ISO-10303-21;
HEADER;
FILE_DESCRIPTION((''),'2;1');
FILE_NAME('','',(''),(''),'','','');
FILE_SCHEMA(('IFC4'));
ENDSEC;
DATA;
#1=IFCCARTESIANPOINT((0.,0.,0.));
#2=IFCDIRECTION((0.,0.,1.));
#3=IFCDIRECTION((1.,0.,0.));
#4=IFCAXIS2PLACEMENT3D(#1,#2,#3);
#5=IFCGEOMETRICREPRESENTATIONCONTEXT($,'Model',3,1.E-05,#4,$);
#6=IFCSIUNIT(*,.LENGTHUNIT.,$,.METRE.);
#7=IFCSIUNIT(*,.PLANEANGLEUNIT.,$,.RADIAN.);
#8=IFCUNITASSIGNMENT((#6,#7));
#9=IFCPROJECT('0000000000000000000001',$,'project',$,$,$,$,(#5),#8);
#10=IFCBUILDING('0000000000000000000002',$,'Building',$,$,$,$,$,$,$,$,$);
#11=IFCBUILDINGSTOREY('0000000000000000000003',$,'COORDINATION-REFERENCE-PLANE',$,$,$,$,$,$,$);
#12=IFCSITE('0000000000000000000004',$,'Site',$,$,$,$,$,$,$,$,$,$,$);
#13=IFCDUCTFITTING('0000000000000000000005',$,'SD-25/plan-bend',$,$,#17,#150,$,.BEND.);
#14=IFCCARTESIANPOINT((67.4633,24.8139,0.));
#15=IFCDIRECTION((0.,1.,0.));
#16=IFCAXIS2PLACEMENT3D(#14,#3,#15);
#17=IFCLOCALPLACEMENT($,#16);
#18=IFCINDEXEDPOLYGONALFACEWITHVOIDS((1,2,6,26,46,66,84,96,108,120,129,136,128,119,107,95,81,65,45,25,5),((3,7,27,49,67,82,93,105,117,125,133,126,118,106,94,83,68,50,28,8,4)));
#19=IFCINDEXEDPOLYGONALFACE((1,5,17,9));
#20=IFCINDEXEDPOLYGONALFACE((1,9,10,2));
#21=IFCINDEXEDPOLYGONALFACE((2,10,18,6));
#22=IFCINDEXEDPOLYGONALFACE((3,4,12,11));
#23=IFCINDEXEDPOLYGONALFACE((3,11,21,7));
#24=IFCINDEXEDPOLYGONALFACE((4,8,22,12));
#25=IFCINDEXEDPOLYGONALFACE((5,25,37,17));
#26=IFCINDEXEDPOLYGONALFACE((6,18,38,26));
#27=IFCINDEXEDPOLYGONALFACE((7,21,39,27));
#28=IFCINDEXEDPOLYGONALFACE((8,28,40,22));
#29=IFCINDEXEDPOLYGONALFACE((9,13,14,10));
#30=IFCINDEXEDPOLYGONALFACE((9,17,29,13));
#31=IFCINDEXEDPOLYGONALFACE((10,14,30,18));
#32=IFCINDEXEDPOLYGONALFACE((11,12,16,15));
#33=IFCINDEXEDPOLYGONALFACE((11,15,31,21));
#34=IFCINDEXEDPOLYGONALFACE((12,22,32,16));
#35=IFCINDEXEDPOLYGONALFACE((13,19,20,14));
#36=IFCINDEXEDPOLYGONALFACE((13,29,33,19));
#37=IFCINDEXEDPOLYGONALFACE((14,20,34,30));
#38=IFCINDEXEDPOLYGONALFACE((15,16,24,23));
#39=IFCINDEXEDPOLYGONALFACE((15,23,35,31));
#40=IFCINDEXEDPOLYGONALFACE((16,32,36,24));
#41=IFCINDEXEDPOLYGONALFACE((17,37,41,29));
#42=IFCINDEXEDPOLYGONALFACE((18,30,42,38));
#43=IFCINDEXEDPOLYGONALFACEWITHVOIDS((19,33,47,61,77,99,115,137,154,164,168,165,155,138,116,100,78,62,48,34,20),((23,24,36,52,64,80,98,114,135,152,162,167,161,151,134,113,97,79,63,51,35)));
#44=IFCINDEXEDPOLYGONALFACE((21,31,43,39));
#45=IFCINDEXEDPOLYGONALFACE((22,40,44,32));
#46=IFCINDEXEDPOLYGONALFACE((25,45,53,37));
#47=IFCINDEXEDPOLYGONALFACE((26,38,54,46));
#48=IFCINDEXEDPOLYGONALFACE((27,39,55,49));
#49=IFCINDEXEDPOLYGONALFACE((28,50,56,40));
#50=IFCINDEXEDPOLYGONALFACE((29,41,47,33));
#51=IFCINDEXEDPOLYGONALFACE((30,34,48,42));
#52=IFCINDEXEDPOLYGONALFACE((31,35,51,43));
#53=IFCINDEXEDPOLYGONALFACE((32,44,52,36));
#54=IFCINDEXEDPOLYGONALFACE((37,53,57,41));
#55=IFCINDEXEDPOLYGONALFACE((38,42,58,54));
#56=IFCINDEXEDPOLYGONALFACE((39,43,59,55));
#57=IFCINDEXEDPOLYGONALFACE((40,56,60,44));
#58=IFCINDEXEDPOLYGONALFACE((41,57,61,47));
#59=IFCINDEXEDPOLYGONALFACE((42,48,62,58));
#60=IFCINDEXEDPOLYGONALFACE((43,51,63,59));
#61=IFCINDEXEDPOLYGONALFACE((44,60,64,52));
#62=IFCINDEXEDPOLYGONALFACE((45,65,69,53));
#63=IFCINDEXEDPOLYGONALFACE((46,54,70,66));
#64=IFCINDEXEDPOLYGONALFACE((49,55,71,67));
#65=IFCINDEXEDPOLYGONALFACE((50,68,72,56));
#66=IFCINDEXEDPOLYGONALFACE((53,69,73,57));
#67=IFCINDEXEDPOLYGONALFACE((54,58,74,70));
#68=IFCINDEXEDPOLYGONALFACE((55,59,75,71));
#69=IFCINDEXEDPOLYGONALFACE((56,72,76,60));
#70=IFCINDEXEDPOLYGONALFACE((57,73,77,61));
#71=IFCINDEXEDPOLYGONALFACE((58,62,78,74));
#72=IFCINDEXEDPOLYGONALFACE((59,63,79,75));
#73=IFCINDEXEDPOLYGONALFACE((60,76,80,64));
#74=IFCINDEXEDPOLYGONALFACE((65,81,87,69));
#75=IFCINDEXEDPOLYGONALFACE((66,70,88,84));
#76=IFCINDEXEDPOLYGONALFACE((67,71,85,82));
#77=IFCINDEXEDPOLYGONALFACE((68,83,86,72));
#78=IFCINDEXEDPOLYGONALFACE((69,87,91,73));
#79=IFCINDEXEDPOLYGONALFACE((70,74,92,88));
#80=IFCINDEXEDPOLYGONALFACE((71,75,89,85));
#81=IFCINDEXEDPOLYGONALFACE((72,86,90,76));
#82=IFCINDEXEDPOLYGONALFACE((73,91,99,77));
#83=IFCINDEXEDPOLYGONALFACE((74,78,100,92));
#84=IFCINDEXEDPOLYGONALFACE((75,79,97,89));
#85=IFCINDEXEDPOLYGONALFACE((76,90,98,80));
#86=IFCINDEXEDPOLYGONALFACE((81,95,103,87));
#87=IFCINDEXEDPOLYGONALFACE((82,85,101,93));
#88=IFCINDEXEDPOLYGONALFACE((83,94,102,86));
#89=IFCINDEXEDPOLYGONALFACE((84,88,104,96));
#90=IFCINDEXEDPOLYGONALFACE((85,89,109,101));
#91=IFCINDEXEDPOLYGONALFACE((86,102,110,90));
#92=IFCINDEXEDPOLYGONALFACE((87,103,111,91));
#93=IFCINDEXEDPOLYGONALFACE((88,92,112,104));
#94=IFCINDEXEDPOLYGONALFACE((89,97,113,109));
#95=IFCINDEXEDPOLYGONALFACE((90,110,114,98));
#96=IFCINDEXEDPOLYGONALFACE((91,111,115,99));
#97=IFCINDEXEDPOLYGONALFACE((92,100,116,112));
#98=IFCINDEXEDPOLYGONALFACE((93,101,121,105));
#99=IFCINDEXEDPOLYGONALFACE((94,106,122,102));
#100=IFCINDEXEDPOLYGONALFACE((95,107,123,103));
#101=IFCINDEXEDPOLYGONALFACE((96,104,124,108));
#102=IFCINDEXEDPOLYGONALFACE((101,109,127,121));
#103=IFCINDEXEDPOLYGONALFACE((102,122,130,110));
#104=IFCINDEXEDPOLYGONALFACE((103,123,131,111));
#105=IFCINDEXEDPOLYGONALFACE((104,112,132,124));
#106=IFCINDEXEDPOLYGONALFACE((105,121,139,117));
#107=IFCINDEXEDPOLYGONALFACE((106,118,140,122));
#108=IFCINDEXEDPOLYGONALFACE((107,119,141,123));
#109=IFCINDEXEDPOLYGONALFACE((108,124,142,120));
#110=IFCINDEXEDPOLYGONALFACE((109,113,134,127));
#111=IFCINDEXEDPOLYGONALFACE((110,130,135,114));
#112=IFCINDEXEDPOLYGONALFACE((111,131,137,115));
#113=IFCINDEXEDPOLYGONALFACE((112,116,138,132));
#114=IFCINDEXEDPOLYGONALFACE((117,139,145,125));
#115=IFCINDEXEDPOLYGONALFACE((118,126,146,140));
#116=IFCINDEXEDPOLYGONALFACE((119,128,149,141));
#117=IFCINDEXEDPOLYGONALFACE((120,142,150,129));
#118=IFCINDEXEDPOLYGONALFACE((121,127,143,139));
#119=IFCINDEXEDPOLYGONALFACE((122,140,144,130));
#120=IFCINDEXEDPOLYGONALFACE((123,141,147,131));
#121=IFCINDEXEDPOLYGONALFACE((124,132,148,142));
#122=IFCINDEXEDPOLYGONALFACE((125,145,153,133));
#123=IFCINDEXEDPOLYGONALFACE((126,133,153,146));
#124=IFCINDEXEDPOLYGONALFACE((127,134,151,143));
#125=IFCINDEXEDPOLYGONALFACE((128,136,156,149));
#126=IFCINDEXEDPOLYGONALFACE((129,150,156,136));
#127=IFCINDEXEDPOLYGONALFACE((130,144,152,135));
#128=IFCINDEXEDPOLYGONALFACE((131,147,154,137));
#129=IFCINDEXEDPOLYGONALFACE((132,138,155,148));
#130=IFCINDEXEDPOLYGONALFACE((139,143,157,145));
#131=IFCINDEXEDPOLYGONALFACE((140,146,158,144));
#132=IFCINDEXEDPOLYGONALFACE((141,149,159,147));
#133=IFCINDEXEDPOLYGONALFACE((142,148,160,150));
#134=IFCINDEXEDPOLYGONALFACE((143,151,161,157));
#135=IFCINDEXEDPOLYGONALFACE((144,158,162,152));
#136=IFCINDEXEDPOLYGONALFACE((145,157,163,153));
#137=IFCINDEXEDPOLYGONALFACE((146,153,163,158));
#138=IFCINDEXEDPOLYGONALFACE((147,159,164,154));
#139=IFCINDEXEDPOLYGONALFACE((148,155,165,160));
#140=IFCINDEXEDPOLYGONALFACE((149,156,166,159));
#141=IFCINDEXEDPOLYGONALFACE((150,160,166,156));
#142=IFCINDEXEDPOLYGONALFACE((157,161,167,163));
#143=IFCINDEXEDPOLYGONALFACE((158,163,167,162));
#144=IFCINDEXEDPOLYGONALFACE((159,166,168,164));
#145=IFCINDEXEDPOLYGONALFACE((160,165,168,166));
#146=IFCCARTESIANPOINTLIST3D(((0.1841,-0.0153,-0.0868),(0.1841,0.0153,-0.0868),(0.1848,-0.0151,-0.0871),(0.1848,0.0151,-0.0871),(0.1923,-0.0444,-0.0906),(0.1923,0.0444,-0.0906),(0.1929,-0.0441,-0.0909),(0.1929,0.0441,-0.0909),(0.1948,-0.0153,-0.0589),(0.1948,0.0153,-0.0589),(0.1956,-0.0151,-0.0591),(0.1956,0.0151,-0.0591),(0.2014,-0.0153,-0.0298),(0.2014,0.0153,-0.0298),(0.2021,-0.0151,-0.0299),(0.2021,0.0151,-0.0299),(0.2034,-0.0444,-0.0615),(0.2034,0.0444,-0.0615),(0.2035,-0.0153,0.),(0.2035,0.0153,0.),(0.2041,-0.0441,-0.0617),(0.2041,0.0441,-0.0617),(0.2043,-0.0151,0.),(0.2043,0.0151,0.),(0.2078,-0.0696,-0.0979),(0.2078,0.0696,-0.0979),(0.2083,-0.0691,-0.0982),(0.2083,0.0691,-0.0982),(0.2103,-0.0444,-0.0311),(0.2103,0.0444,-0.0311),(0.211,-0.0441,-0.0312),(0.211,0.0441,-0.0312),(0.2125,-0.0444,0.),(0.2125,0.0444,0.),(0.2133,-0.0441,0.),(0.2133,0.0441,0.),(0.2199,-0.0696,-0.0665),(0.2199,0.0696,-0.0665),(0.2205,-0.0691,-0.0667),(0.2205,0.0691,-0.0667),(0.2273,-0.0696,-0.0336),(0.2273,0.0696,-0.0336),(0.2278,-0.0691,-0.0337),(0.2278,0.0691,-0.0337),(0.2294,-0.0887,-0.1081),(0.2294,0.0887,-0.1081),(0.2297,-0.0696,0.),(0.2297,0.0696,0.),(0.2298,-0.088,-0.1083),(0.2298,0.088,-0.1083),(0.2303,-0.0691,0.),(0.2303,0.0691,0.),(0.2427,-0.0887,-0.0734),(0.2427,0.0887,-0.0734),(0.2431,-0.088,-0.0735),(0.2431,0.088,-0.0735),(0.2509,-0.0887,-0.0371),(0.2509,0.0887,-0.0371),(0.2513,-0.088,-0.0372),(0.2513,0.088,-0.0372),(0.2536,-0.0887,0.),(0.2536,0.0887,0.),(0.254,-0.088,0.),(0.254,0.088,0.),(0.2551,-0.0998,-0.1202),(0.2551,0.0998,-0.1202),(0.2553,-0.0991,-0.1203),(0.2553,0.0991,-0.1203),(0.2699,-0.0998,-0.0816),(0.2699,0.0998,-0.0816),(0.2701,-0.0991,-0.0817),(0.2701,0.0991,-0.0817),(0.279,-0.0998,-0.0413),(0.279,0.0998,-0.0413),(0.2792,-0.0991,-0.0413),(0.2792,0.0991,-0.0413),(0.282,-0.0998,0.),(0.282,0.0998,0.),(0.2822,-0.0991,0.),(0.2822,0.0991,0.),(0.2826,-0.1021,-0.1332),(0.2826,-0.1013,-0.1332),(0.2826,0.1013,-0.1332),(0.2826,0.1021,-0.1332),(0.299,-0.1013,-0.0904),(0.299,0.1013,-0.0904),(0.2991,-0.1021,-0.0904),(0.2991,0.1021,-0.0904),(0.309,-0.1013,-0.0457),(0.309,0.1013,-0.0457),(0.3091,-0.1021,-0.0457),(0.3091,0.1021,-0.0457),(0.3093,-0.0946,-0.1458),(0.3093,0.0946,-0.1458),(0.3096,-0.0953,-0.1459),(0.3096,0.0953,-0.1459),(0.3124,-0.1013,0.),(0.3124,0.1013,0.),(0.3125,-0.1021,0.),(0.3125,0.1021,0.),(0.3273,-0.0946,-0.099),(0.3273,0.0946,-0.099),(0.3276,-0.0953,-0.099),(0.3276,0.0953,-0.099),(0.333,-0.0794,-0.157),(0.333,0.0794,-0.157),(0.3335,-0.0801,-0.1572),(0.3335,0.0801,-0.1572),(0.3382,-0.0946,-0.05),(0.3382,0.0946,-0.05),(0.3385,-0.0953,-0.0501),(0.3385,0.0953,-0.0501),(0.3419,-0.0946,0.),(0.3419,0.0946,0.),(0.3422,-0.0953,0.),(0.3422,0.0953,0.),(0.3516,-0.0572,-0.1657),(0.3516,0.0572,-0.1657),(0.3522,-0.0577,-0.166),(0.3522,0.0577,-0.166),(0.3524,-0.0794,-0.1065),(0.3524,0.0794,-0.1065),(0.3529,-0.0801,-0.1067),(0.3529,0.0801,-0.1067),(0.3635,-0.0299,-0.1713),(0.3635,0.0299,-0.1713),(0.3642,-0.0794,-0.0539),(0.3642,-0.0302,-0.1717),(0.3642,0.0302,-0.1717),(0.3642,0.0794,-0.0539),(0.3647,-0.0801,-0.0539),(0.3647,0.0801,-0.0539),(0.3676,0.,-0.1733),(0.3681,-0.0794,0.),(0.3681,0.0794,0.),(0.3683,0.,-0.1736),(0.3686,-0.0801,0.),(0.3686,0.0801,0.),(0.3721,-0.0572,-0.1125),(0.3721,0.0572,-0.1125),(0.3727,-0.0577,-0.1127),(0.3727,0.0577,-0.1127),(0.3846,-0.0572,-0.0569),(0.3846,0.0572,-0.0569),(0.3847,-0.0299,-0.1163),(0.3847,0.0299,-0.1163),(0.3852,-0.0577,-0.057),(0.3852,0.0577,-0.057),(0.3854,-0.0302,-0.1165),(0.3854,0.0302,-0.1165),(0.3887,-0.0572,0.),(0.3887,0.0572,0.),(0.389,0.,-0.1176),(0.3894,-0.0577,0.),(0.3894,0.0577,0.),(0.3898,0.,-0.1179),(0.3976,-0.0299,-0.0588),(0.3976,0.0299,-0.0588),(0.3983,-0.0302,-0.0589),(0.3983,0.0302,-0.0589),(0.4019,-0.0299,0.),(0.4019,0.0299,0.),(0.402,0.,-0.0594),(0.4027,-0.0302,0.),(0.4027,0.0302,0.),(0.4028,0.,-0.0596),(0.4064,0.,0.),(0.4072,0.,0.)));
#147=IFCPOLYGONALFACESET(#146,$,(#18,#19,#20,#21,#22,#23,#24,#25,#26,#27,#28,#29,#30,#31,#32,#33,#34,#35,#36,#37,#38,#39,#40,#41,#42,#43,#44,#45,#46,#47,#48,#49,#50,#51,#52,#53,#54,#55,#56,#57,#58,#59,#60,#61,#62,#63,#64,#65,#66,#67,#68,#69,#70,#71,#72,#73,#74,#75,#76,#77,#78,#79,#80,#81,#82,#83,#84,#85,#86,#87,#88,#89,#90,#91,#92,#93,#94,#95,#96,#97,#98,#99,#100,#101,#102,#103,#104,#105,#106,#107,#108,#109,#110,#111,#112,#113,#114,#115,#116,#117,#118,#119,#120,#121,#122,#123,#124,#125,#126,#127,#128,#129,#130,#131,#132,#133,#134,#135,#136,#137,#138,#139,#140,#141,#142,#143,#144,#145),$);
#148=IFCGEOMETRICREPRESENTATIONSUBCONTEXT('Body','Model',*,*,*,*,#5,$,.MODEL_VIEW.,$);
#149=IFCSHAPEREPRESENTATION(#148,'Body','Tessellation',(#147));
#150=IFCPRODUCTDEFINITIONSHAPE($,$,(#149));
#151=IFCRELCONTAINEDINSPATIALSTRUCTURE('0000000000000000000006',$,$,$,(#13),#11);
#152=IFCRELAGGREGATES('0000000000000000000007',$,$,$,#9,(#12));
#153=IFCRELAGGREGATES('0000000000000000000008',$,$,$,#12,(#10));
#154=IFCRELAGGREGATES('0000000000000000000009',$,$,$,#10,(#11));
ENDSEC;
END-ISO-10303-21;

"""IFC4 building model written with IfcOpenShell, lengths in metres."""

from ifc_helpers import new_model, entity, si_unit, frame, origin_with_axes, place, context, subcontext, project, spatial, element, save


model = new_model("IFC4")

# Units and contexts
model_context = context("Model", 3, precision=1e-05, world=origin_with_axes())
body_context_1 = subcontext(model_context, "Body", "Model", "MODEL_VIEW")
ifc_project = project(units=[si_unit("LENGTHUNIT", "METRE"), si_unit("PLANEANGLEUNIT", "RADIAN")], contexts=[model_context])

# Site, building, storey
site = spatial("IfcSite", under=ifc_project, Name="Site")
building = spatial("IfcBuilding", under=site, Name="Building")
storey = spatial("IfcBuildingStorey", under=building, Name="COORDINATION-REFERENCE-PLANE")

# Duct fitting
duct_fitting_1_placement = place(None, frame((67.4633, 24.8139, 0.0), z_axis=(1.0, 0.0, 0.0), x_axis=(0.0, 1.0, 0.0)))
element("IfcDuctFitting", 1, at=duct_fitting_1_placement, inside=storey, Name="SD-25/plan-bend", PredefinedType="BEND", context=body_context_1, shape_type="SweptSolid", body=[
    entity("IfcRevolvedAreaSolid", entity("IfcCircleHollowProfileDef", "AREA", None, entity("IfcAxis2Placement2D", entity("IfcCartesianPoint", [0.3048, 0.0])), 0.1024, 0.0008), entity("IfcAxis2Placement3D", entity("IfcCartesianPoint", [0.0, 0.0, 0.0]), entity("IfcDirection", [0.0, 0.0, 1.0]), entity("IfcDirection", [1.0, 0.0, 0.0])), entity("IfcAxis1Placement", entity("IfcCartesianPoint", [0.0, 0.0, 0.0]), entity("IfcDirection", [0.0, 1.0, 0.0])), 0.440428),
])

save(model, "model.ifc")
